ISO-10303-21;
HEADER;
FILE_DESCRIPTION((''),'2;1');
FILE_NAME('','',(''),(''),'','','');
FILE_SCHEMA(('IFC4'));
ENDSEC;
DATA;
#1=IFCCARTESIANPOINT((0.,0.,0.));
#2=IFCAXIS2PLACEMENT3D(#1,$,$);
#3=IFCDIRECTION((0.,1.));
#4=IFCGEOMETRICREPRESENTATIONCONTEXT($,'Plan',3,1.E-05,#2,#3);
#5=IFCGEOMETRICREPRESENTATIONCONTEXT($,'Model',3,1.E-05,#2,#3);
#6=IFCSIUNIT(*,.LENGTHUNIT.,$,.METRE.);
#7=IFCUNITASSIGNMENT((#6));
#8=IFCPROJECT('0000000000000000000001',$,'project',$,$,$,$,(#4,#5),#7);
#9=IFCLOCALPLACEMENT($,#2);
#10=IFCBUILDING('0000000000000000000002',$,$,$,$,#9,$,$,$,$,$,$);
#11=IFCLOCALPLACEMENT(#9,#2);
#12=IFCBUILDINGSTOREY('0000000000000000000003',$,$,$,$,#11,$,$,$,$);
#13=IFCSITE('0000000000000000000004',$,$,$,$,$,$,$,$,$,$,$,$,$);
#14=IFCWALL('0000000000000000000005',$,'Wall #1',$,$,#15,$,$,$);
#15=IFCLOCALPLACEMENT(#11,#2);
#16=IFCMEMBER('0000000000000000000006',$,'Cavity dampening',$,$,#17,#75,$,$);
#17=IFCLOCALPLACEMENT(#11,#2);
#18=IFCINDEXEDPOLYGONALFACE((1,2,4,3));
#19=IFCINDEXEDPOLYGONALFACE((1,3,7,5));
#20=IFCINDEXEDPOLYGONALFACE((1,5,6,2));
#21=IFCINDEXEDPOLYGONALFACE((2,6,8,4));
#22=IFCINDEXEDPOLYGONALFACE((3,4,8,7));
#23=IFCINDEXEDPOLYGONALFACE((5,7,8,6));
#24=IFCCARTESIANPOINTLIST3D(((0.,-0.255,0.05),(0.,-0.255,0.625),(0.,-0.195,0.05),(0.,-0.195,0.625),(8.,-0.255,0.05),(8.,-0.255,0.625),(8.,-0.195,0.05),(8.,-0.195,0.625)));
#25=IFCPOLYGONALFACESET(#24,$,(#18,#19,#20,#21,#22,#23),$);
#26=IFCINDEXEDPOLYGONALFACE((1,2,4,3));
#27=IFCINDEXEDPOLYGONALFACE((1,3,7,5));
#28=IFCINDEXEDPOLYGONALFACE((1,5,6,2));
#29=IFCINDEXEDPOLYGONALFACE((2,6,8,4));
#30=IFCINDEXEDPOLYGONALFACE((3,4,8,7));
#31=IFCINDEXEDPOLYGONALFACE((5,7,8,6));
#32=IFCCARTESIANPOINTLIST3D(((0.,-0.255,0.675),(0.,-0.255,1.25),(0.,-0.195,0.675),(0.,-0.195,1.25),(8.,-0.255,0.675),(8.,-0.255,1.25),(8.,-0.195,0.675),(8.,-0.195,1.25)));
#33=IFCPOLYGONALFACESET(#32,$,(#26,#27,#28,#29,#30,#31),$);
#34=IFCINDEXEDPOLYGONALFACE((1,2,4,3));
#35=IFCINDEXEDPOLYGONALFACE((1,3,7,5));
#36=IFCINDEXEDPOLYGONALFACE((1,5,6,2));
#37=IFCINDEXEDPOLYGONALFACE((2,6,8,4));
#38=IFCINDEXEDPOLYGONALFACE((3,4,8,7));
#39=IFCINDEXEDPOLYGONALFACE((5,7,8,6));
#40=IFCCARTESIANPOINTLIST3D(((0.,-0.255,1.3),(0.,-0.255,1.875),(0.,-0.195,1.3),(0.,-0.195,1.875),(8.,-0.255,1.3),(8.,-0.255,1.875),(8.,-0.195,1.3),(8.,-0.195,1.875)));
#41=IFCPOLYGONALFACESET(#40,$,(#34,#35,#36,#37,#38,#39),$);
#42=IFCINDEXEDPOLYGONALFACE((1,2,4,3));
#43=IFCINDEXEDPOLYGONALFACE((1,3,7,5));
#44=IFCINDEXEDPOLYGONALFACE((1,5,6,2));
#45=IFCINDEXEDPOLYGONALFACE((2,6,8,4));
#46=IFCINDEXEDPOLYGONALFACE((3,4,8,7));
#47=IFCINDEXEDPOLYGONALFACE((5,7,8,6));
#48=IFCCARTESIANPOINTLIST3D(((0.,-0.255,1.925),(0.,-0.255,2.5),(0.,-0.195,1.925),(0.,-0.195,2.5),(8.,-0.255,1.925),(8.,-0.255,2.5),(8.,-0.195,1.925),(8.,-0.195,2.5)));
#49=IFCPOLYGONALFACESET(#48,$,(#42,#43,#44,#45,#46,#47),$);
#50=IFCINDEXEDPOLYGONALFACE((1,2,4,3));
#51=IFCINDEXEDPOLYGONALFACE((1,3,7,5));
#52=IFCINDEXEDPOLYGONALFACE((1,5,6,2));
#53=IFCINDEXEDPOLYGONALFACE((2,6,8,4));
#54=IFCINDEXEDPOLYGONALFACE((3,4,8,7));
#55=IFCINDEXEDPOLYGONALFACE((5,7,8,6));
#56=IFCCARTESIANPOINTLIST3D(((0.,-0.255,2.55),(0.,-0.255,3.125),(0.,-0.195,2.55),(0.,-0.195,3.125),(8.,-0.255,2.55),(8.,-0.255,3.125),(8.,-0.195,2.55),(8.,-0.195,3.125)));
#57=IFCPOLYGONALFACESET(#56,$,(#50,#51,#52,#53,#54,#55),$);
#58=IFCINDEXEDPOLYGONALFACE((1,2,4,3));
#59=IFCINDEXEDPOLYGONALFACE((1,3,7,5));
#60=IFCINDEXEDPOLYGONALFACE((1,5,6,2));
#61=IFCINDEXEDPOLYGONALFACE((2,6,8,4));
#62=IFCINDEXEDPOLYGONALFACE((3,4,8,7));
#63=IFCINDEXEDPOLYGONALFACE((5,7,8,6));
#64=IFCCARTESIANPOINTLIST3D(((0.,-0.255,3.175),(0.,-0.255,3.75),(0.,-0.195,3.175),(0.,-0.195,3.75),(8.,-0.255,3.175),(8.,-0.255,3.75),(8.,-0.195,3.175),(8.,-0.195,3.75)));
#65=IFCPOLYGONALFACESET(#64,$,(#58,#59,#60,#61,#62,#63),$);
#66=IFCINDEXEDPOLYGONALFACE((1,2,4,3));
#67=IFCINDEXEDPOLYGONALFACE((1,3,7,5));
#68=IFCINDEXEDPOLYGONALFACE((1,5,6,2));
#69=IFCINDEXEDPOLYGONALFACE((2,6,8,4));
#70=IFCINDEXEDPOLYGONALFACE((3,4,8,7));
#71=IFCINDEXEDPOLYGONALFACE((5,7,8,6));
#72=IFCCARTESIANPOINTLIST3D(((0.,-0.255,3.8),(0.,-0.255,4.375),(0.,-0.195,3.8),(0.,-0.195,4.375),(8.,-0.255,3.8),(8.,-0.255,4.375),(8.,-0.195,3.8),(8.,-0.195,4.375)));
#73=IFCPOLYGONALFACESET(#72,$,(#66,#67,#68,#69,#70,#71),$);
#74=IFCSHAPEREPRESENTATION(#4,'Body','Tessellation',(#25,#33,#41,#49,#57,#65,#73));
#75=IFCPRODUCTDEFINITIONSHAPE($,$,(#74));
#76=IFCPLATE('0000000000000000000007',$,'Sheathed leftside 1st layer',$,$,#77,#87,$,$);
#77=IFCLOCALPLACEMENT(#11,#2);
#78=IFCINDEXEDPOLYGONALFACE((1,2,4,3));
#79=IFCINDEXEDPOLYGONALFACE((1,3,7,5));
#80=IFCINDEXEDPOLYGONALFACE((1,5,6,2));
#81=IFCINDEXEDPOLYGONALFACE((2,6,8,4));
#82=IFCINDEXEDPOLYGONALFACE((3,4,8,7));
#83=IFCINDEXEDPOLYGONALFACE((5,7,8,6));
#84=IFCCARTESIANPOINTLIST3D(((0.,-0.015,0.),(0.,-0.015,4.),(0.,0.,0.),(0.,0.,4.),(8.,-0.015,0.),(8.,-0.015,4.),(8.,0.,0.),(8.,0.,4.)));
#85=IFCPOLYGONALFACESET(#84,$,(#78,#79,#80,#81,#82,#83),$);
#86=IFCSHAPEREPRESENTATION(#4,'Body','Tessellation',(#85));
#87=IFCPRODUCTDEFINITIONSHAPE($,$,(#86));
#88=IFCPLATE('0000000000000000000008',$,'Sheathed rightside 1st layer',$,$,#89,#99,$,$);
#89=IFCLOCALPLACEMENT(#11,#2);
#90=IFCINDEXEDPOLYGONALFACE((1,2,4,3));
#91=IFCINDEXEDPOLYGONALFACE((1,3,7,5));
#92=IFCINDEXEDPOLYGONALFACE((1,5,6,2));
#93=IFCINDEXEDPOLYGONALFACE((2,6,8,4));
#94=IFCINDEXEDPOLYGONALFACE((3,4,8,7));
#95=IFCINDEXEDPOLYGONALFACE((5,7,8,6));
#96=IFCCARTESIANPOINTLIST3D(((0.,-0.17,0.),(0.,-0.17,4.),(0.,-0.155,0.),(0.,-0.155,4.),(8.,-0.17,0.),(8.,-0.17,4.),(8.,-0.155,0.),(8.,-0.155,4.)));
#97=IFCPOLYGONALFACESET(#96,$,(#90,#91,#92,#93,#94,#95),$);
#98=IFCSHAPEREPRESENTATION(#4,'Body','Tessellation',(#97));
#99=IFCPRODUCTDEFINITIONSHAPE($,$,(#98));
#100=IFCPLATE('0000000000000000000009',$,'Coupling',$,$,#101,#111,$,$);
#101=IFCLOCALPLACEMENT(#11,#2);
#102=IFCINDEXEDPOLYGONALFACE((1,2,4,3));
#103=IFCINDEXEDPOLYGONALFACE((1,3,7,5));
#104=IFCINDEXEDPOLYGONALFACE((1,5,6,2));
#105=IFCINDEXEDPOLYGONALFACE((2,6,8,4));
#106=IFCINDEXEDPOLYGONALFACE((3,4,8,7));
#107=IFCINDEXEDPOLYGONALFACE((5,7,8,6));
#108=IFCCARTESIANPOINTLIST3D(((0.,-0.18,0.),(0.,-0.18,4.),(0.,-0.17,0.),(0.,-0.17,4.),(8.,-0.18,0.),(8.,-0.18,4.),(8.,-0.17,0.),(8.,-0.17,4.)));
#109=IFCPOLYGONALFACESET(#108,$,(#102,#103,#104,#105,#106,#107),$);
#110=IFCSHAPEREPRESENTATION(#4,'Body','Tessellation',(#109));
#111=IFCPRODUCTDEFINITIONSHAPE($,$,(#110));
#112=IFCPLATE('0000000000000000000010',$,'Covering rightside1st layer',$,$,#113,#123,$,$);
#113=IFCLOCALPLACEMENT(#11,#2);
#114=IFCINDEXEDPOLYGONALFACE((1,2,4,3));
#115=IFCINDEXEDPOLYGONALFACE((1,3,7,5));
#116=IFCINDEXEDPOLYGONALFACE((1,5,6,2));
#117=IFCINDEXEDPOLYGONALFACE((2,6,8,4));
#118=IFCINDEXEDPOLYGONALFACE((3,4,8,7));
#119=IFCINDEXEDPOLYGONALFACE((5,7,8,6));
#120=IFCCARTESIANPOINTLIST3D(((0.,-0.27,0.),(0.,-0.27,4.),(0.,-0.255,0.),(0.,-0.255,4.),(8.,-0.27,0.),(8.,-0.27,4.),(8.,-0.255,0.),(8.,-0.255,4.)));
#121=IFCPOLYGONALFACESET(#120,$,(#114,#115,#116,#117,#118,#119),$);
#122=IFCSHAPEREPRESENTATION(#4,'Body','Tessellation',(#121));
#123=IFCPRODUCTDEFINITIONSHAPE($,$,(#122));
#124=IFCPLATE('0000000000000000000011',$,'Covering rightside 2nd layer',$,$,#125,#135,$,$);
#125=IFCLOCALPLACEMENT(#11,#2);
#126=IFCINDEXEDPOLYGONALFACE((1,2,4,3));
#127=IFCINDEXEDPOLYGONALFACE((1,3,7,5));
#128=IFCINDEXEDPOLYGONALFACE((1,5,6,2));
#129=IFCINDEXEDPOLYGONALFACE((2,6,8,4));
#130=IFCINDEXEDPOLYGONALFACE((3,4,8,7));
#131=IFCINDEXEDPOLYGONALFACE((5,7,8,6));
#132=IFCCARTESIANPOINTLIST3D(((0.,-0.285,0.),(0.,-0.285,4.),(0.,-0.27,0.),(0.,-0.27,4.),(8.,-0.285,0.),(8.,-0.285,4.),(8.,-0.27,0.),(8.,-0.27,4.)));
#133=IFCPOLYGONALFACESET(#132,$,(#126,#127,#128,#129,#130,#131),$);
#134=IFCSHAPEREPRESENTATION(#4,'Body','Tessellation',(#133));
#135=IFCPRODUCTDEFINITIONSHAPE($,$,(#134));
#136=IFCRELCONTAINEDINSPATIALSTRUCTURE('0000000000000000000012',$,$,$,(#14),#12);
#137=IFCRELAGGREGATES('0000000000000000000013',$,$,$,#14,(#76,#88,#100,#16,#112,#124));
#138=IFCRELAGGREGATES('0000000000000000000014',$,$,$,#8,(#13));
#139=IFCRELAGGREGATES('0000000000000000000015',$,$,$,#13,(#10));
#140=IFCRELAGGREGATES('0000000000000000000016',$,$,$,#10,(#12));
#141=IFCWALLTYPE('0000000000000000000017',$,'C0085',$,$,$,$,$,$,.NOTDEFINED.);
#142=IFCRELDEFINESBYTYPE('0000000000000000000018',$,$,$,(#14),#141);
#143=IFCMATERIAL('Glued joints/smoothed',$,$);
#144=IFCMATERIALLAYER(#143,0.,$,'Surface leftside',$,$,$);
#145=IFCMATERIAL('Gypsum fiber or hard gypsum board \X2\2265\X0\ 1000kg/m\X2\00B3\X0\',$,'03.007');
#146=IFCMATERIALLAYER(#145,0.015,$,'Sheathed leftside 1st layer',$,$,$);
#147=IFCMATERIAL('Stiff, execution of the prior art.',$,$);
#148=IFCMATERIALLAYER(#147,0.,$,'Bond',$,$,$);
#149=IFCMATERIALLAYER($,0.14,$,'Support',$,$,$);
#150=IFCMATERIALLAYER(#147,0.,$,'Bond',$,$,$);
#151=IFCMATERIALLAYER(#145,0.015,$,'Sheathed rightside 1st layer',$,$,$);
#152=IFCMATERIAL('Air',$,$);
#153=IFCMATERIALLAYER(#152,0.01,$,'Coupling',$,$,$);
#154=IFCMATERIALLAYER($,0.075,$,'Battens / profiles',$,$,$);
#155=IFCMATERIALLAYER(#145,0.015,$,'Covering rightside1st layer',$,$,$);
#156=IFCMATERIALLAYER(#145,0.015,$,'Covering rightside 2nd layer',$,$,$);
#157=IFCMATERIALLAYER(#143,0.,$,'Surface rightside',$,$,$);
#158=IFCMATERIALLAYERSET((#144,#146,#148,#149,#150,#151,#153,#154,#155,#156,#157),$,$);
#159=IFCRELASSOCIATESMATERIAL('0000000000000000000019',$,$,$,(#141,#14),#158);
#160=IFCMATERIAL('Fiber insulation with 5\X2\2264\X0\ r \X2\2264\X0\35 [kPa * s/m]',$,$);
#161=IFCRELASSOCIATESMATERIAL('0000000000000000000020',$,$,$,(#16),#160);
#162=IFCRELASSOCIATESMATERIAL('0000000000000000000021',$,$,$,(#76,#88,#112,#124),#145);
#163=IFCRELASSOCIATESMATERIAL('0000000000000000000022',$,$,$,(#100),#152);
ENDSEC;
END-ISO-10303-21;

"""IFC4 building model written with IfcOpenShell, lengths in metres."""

from ifc_helpers import new_model, si_unit, direction, frame, frame_2d, origin, origin_with_axes, place, context, project, spatial, rectangle, extrude, material, layer, layer_set, type_object, element, aggregate, save


model = new_model("IFC4")

# Units and contexts
plan_context = context("Plan", 3, precision=1e-05, world=origin(), true_north=direction((0.0, 1.0)))
model_context = context("Model", 3, precision=1e-05, world=origin(), true_north=direction((0.0, 1.0)))
ifc_project = project(units=[si_unit("LENGTHUNIT", "METRE")], contexts=[plan_context, model_context])

# Site, building, storey
site = spatial("IfcSite", under=ifc_project)
building_placement = place(None, origin())
building = spatial("IfcBuilding", under=site, at=building_placement)
storey_placement = place(building_placement, origin())
storey = spatial("IfcBuildingStorey", under=building, at=storey_placement)

# Wall, member, plates
ifc_material_1 = material(Name="Glued joints/smoothed")
ifc_layer_1 = layer(ifc_material_1, 0.0, Name="Surface leftside")
ifc_material_2 = material(Name="Gypsum fiber or hard gypsum board ≥ 1000kg/m³", Category="03.007")
ifc_layer_2 = layer(ifc_material_2, 0.015, Name="Sheathed leftside 1st layer")
ifc_material_3 = material(Name="Stiff, execution of the prior art.")
ifc_layer_3 = layer(ifc_material_3, 0.0, Name="Bond")
ifc_layer_4 = layer(None, 0.14, Name="Support")
ifc_layer_5 = layer(ifc_material_3, 0.0, Name="Bond")
ifc_layer_6 = layer(ifc_material_2, 0.015, Name="Sheathed rightside 1st layer")
ifc_material_4 = material(Name="Air")
ifc_layer_7 = layer(ifc_material_4, 0.01, Name="Coupling")
ifc_layer_8 = layer(None, 0.075, Name="Battens / profiles")
ifc_layer_9 = layer(ifc_material_2, 0.015, Name="Covering rightside1st layer")
ifc_layer_10 = layer(ifc_material_2, 0.015, Name="Covering rightside 2nd layer")
ifc_layer_11 = layer(ifc_material_1, 0.0, Name="Surface rightside")
ifc_layer_set = layer_set([ifc_layer_1, ifc_layer_2, ifc_layer_3, ifc_layer_4, ifc_layer_5, ifc_layer_6, ifc_layer_7, ifc_layer_8, ifc_layer_9, ifc_layer_10, ifc_layer_11])
wall_type = type_object("IfcWallType", Name="C0085", PredefinedType="NOTDEFINED", material=ifc_layer_set)
wall_placement = place(None, frame((0.0, 0.0, 0.0), z_axis=(0.0, -1.0, 0.0), x_axis=(1.0, 0.0, 0.0)))
wall = element("IfcWall", 1, at=wall_placement, inside=storey, type_object=wall_type, material=ifc_layer_set, Name="Wall #1")
ifc_material_5 = material(Name="Fiber insulation with 5≤ r ≤35 [kPa * s/m]")
member_1_placement = place(wall_placement, origin())
member_1 = element("IfcMember", 2, at=member_1_placement, material=ifc_material_5, Name="Cavity dampening", context=plan_context, shape_type="SweptSolid", body=[
    extrude(rectangle(XDim=0.575, YDim=0.06, at=frame_2d((0.2875, 0.03), x_axis=(1.0, 0.0))), frame((0.0, 0.05, 0.195), z_axis=(1.0, 0.0, 0.0), x_axis=(0.0, 1.0, 0.0)), (0.0, 0.0, 1.0), 8.0),
    extrude(rectangle(XDim=0.575, YDim=0.06, at=frame_2d((0.2875, 0.03), x_axis=(1.0, 0.0))), frame((0.0, 0.675, 0.195), z_axis=(1.0, 0.0, 0.0), x_axis=(0.0, 1.0, 0.0)), (0.0, 0.0, 1.0), 8.0),
    extrude(rectangle(XDim=0.575, YDim=0.06, at=frame_2d((0.2875, 0.03), x_axis=(1.0, 0.0))), frame((0.0, 1.3, 0.195), z_axis=(1.0, 0.0, 0.0), x_axis=(0.0, 1.0, 0.0)), (0.0, 0.0, 1.0), 8.0),
    extrude(rectangle(XDim=0.575, YDim=0.06, at=frame_2d((0.2875, 0.03), x_axis=(1.0, 0.0))), frame((0.0, 1.925, 0.195), z_axis=(1.0, 0.0, 0.0), x_axis=(0.0, 1.0, 0.0)), (0.0, 0.0, 1.0), 8.0),
    extrude(rectangle(XDim=0.575, YDim=0.06, at=frame_2d((0.2875, 0.03), x_axis=(1.0, 0.0))), frame((0.0, 2.55, 0.195), z_axis=(1.0, 0.0, 0.0), x_axis=(0.0, 1.0, 0.0)), (0.0, 0.0, 1.0), 8.0),
    extrude(rectangle(XDim=0.575, YDim=0.06, at=frame_2d((0.2875, 0.03), x_axis=(1.0, 0.0))), frame((0.0, 3.175, 0.195), z_axis=(1.0, 0.0, 0.0), x_axis=(0.0, 1.0, 0.0)), (0.0, 0.0, 1.0), 8.0),
    extrude(rectangle(XDim=0.575, YDim=0.06, at=frame_2d((0.2875, 0.03), x_axis=(1.0, 0.0))), frame((0.0, 3.8, 0.195), z_axis=(1.0, 0.0, 0.0), x_axis=(0.0, 1.0, 0.0)), (0.0, 0.0, 1.0), 8.0),
])
plate_1_placement = place(wall_placement, origin())
plate_1 = element("IfcPlate", 3, at=plate_1_placement, material=ifc_material_2, Name="Sheathed leftside 1st layer", context=plan_context, shape_type="SweptSolid", body=[
    extrude(rectangle(XDim=8.0, YDim=4.0, at=frame_2d((4.0, 2.0), x_axis=(1.0, 0.0))), origin_with_axes(), (0.0, 0.0, 1.0), 0.015),
])
plate_2_placement = place(wall_placement, origin())
plate_2 = element("IfcPlate", 4, at=plate_2_placement, material=ifc_material_2, Name="Sheathed rightside 1st layer", context=plan_context, shape_type="SweptSolid", body=[
    extrude(rectangle(XDim=8.0, YDim=4.0, at=frame_2d((4.0, 2.0), x_axis=(1.0, 0.0))), frame((0.0, 0.0, 0.155), z_axis=(0.0, 0.0, 1.0), x_axis=(1.0, 0.0, 0.0)), (0.0, 0.0, 1.0), 0.015),
])
plate_3_placement = place(wall_placement, origin())
plate_3 = element("IfcPlate", 5, at=plate_3_placement, material=ifc_material_4, Name="Coupling", context=plan_context, shape_type="SweptSolid", body=[
    extrude(rectangle(XDim=8.0, YDim=4.0, at=frame_2d((4.0, 2.0), x_axis=(1.0, 0.0))), frame((0.0, 0.0, 0.17), z_axis=(0.0, 0.0, 1.0), x_axis=(1.0, 0.0, 0.0)), (0.0, 0.0, 1.0), 0.01),
])
plate_4_placement = place(wall_placement, origin())
plate_4 = element("IfcPlate", 6, at=plate_4_placement, material=ifc_material_2, Name="Covering rightside1st layer", context=plan_context, shape_type="SweptSolid", body=[
    extrude(rectangle(XDim=8.0, YDim=4.0, at=frame_2d((4.0, 2.0), x_axis=(1.0, 0.0))), frame((0.0, 0.0, 0.255), z_axis=(0.0, 0.0, 1.0), x_axis=(1.0, 0.0, 0.0)), (0.0, 0.0, 1.0), 0.015),
])
plate_5_placement = place(wall_placement, origin())
plate_5 = element("IfcPlate", 7, at=plate_5_placement, material=ifc_material_2, Name="Covering rightside 2nd layer", context=plan_context, shape_type="SweptSolid", body=[
    extrude(rectangle(XDim=8.0, YDim=4.0, at=frame_2d((4.0, 2.0), x_axis=(1.0, 0.0))), frame((0.0, 0.0, 0.27), z_axis=(0.0, 0.0, 1.0), x_axis=(1.0, 0.0, 0.0)), (0.0, 0.0, 1.0), 0.015),
])
aggregate(wall, [plate_1, plate_2, plate_3, member_1, plate_4, plate_5])

save(model, "model.ifc")
